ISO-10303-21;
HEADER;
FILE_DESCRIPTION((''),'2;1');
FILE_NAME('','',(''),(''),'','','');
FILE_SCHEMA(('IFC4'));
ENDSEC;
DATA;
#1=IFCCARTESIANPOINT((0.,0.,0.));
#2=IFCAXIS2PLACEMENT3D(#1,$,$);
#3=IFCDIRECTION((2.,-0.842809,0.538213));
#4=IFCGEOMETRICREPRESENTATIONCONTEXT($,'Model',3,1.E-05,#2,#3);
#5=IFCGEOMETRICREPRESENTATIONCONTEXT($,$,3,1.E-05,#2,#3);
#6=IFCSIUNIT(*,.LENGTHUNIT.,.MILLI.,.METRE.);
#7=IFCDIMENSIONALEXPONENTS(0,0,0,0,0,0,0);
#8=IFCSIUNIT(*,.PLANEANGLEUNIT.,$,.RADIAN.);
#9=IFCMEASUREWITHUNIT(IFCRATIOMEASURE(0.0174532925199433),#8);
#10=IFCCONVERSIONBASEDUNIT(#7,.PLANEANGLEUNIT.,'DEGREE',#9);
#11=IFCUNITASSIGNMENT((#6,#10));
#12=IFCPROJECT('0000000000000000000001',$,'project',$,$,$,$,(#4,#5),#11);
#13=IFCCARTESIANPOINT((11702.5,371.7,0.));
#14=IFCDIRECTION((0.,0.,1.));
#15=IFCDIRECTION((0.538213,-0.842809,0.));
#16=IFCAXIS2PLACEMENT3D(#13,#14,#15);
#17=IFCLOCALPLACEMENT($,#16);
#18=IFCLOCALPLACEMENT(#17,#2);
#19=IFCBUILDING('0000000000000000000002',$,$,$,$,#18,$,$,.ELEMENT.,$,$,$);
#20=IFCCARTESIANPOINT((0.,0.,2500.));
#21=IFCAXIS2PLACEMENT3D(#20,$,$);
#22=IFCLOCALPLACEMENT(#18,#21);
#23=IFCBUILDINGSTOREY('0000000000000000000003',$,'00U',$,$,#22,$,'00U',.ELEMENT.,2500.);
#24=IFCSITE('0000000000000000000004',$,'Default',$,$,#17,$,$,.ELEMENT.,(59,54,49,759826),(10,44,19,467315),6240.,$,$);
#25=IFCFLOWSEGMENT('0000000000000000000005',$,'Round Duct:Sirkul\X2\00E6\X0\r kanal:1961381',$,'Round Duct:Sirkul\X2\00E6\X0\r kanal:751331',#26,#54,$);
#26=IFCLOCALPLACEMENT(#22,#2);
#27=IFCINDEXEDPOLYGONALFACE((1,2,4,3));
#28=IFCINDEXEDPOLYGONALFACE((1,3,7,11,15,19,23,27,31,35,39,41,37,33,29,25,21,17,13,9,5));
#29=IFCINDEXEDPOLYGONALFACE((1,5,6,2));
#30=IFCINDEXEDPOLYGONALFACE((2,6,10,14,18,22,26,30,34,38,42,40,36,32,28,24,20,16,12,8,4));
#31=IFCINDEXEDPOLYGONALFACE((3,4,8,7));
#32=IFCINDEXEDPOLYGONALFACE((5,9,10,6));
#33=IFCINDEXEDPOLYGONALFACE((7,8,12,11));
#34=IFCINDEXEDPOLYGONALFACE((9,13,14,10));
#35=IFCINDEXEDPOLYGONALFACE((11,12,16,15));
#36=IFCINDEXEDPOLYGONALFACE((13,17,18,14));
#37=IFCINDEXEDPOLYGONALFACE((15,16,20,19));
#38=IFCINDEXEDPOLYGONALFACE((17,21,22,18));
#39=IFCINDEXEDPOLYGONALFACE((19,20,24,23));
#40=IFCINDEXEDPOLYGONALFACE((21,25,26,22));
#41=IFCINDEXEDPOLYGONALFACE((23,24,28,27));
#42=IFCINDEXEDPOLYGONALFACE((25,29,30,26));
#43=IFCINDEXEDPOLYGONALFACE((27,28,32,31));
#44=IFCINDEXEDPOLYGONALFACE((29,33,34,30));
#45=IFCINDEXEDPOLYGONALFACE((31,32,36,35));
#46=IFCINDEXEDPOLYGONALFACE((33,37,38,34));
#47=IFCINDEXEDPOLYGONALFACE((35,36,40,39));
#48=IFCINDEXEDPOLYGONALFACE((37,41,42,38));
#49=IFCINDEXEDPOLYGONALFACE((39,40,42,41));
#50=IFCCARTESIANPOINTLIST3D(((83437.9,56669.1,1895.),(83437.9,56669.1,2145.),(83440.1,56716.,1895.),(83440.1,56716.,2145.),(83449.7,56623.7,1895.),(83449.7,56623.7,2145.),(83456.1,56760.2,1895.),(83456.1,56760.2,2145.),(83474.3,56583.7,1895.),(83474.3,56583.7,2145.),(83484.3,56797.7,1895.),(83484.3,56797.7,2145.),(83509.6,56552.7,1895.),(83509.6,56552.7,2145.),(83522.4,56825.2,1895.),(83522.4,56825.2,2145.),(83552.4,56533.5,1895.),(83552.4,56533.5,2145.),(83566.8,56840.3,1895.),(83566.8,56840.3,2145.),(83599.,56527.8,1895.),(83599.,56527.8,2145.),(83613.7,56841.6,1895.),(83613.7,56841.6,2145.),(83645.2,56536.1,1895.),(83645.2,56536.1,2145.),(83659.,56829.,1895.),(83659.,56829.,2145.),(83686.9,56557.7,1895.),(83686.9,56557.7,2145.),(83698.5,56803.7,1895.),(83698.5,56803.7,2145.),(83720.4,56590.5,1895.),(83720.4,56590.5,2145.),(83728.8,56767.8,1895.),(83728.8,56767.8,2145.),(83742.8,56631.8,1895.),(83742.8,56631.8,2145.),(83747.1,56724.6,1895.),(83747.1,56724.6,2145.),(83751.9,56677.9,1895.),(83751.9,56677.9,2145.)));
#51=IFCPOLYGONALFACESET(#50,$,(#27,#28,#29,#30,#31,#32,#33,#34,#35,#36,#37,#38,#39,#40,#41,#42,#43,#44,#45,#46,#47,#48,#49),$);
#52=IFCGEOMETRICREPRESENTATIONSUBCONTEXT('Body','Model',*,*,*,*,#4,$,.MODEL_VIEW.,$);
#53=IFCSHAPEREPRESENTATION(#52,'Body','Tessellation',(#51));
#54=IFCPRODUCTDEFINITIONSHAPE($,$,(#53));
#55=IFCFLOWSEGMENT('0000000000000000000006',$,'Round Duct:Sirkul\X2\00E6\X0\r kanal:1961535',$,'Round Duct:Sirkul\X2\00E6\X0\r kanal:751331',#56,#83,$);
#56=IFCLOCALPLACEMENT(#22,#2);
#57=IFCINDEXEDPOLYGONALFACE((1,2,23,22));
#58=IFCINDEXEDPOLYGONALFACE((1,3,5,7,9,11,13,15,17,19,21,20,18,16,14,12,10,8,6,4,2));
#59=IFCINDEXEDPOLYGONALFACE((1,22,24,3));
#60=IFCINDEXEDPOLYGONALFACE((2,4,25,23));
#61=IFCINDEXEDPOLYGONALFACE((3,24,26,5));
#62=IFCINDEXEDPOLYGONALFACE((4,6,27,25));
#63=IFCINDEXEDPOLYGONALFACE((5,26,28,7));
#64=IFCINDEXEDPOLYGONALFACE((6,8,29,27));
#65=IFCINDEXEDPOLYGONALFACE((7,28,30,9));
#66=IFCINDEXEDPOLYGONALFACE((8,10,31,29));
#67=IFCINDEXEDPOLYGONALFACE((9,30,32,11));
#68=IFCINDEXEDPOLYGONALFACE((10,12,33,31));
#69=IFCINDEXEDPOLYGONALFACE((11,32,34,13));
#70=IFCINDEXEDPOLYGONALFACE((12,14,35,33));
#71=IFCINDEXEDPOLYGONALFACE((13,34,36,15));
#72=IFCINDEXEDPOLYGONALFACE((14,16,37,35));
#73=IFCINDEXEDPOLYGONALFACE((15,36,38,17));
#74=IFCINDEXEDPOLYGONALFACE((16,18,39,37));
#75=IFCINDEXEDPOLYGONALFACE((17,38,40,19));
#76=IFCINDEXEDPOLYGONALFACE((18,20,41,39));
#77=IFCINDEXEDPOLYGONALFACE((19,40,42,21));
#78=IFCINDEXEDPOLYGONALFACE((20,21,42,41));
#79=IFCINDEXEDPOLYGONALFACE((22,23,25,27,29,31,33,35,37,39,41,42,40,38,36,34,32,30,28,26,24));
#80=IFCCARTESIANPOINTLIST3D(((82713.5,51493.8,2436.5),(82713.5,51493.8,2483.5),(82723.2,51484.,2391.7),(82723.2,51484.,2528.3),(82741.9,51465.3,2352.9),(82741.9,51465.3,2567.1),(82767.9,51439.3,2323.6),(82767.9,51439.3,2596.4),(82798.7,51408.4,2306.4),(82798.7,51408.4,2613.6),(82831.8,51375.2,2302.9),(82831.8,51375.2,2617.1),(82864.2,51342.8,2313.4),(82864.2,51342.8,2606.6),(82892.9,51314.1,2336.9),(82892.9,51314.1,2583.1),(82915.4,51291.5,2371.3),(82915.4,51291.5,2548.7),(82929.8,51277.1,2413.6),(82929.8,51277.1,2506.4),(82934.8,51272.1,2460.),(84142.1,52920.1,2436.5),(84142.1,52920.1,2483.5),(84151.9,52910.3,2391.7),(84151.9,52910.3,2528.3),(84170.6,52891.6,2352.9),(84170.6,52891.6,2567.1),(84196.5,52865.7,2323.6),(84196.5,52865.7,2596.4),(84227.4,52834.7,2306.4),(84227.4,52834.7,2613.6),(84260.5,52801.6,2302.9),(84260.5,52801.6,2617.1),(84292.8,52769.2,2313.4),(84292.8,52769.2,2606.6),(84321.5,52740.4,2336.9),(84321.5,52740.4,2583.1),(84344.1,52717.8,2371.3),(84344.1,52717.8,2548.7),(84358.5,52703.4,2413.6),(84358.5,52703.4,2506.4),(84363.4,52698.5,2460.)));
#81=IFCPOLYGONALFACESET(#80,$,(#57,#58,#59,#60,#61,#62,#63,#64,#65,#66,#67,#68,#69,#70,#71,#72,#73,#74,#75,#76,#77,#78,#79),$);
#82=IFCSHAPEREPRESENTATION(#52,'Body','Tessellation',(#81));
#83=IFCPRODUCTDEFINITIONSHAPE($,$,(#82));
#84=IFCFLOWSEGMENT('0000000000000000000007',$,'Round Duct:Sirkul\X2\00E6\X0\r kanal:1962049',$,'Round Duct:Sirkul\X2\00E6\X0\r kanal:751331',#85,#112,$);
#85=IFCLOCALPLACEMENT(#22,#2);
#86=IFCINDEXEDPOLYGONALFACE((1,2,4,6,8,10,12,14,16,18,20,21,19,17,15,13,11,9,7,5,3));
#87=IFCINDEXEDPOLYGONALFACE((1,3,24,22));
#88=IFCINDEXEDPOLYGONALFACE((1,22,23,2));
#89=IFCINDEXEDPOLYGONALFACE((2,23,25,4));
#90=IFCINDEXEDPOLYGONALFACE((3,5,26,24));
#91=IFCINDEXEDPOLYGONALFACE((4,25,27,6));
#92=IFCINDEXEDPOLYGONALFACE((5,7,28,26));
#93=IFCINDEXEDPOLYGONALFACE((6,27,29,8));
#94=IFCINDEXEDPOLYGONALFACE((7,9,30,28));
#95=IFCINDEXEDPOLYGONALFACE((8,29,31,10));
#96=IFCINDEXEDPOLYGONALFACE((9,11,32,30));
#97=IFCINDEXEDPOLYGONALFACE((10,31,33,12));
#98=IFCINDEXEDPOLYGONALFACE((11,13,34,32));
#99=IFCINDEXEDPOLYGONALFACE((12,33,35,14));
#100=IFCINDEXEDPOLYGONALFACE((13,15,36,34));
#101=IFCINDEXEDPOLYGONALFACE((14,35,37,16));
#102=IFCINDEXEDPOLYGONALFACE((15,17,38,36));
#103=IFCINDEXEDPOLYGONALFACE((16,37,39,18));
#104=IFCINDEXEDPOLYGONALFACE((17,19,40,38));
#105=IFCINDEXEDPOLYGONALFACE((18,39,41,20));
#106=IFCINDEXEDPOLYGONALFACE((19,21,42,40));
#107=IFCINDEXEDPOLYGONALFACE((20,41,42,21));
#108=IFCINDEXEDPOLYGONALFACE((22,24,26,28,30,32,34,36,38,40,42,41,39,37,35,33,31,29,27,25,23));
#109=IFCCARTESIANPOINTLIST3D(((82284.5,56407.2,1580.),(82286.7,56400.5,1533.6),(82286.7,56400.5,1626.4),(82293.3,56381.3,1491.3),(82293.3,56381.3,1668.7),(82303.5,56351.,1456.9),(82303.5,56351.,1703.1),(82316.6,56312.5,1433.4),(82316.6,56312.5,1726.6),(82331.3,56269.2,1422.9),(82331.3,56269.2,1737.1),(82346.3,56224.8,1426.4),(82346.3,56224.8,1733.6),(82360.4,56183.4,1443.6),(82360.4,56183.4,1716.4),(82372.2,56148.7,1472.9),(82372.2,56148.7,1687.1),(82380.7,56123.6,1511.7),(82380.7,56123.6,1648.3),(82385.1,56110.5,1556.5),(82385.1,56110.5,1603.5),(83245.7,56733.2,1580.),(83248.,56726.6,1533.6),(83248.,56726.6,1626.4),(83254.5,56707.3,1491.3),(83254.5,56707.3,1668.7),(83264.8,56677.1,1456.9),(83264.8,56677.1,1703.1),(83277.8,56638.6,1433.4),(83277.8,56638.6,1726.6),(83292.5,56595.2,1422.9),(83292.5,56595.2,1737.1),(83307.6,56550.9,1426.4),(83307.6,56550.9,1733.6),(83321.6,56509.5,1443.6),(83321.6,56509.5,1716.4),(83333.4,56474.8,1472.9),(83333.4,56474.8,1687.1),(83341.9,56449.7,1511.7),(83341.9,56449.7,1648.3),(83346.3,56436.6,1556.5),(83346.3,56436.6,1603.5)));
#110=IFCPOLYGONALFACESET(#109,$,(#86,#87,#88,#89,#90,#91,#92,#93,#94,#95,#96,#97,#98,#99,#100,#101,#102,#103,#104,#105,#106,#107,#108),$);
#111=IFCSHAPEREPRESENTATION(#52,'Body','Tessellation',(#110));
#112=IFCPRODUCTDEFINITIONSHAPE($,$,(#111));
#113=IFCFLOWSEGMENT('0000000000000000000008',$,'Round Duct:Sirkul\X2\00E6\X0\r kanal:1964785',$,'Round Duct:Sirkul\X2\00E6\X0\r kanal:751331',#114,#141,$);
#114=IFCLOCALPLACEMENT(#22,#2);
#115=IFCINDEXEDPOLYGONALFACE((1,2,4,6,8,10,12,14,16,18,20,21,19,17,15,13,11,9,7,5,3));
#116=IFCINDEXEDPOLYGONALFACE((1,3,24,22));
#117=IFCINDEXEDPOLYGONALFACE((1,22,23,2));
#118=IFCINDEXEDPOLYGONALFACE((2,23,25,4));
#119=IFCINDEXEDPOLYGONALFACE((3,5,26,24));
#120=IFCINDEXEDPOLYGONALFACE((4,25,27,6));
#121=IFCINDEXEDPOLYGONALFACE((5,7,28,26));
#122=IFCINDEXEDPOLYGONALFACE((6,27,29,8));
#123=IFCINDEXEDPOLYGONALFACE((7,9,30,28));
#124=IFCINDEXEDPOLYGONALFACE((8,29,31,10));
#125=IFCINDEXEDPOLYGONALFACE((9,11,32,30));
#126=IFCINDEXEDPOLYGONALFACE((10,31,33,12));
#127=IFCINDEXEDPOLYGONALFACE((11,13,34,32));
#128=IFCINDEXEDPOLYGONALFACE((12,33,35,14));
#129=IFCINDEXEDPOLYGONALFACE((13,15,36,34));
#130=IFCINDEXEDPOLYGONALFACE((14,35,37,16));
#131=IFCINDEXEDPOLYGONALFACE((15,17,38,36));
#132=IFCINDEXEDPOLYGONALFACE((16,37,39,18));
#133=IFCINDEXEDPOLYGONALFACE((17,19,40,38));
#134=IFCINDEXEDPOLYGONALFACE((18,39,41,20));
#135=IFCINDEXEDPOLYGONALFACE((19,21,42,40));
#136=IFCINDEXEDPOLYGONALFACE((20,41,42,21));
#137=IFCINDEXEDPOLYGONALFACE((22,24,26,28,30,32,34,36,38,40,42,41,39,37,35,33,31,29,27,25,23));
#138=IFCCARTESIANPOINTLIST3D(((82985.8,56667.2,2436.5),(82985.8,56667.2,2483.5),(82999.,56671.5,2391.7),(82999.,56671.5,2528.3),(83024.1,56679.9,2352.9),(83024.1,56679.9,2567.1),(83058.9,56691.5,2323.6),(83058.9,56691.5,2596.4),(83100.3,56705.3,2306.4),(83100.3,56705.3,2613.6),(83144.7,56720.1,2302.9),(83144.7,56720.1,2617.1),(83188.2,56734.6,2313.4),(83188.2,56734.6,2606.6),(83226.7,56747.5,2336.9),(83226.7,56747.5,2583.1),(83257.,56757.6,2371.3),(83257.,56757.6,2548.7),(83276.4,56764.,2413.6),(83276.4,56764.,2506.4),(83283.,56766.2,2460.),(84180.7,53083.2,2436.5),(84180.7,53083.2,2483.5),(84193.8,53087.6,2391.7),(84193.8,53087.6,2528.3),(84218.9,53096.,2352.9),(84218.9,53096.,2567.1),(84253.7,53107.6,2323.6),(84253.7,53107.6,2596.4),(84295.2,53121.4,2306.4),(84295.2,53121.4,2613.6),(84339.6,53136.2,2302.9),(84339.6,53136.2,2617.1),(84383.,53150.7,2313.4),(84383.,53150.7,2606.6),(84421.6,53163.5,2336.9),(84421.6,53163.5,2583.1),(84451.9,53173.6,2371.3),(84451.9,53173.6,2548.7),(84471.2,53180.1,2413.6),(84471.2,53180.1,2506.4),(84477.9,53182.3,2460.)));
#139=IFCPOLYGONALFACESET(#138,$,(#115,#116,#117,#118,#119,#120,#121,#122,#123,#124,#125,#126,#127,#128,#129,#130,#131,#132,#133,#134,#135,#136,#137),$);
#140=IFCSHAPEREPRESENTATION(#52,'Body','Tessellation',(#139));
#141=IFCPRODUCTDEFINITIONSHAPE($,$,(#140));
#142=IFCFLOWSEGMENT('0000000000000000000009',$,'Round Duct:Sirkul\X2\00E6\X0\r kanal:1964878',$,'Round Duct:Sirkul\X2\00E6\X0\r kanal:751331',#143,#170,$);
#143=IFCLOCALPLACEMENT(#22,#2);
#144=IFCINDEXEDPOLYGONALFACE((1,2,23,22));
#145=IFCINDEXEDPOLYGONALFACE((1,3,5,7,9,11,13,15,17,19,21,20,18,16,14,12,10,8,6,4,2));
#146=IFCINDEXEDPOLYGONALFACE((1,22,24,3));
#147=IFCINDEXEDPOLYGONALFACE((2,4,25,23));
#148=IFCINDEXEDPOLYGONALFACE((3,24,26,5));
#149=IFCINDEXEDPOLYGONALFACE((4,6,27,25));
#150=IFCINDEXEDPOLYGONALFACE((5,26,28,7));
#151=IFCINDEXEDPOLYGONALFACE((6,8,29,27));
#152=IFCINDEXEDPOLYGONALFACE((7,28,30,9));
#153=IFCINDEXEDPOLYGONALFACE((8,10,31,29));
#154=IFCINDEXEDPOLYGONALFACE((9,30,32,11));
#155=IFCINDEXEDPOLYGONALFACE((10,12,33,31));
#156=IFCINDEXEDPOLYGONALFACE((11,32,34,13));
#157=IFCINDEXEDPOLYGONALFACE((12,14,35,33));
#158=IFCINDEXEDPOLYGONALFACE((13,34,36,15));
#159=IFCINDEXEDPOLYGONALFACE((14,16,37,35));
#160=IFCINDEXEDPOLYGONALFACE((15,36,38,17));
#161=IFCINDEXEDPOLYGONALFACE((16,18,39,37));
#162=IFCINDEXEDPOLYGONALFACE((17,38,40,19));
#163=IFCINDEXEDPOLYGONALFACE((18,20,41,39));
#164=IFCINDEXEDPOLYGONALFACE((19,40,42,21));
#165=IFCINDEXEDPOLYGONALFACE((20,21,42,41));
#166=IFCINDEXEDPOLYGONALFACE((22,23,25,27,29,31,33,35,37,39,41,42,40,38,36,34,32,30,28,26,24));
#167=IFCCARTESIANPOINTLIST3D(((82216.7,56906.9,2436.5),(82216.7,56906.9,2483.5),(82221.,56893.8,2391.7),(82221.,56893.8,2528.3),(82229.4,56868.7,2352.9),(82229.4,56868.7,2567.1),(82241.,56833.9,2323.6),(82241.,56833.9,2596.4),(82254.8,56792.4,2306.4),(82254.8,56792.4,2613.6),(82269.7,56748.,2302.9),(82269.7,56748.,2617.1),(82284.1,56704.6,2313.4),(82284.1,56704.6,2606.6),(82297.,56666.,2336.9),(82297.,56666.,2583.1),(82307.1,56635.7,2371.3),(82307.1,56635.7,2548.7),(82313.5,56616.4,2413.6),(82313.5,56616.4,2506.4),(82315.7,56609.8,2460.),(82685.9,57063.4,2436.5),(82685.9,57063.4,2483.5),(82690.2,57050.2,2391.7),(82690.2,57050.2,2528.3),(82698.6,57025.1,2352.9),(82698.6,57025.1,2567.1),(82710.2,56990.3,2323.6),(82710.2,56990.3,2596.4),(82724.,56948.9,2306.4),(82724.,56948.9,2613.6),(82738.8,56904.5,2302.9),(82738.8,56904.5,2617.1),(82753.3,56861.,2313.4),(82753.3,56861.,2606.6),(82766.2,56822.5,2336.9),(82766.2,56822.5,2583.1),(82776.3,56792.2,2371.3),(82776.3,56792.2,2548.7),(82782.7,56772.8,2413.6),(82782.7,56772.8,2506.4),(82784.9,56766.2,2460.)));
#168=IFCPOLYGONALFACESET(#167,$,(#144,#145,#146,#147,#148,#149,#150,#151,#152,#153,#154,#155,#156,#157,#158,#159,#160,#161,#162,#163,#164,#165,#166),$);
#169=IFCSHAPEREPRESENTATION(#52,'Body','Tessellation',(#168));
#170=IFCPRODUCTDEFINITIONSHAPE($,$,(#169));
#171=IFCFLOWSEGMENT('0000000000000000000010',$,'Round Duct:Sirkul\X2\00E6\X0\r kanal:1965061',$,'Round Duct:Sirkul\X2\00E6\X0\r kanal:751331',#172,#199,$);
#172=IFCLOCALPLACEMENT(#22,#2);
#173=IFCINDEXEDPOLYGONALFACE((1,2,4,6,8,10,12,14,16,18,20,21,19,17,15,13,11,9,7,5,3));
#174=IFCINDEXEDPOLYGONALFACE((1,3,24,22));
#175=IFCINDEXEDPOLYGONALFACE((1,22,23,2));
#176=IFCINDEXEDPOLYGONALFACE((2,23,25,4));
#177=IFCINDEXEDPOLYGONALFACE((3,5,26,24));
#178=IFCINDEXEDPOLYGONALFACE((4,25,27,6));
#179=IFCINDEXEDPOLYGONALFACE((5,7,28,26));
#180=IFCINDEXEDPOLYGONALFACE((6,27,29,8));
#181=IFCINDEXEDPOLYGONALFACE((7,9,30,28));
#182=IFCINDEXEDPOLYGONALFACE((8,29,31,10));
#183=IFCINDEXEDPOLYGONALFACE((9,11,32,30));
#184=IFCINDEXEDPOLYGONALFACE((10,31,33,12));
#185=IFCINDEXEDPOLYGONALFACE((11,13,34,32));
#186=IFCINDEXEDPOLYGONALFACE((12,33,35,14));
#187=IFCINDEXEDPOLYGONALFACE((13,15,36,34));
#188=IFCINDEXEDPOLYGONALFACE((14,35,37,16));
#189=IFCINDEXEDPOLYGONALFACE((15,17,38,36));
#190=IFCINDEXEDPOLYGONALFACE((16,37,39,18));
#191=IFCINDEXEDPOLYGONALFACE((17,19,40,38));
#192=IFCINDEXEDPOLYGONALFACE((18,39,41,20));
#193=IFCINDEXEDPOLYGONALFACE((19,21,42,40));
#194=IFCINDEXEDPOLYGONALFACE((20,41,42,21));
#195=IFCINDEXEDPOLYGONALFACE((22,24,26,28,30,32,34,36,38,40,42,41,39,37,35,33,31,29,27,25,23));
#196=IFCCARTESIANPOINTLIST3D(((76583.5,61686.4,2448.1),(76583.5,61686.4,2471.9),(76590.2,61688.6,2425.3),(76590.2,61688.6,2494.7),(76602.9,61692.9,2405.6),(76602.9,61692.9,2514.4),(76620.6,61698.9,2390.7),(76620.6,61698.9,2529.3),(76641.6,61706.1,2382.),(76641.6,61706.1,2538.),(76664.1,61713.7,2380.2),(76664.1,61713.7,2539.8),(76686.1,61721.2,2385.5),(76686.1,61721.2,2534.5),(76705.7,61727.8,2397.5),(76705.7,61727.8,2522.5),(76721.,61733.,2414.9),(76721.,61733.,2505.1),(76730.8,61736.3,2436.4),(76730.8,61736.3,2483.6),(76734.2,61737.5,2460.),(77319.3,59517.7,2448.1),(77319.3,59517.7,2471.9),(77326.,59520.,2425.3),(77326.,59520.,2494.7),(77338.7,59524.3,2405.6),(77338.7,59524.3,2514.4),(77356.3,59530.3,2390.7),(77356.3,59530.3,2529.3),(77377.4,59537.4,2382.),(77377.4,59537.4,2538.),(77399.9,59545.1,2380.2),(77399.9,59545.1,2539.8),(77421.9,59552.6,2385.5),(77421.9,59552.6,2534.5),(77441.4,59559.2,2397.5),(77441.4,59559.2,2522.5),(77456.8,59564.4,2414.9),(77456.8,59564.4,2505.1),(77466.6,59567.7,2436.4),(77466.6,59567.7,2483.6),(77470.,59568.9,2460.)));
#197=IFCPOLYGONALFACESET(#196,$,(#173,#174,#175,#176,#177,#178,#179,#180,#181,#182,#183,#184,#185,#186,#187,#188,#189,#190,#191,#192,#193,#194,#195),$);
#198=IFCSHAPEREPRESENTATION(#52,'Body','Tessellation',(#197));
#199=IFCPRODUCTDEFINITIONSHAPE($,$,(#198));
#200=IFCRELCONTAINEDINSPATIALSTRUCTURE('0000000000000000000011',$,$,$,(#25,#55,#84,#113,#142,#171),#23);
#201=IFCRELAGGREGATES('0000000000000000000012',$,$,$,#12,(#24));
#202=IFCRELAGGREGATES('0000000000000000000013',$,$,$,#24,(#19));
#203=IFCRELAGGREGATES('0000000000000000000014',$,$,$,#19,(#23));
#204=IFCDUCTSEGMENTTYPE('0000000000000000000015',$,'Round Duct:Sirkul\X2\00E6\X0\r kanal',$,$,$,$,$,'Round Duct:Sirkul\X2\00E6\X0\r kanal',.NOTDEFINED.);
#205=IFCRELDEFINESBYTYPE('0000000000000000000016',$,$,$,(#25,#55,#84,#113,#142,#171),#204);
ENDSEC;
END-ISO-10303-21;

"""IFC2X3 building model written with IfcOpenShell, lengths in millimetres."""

from ifc_helpers import new_model, entity, si_unit, converted_unit, direction, frame, frame_2d, origin, origin_2d_with_axis, place, context, subcontext, project, spatial, circle, extrude, type_object, element, save


model = new_model("IFC2X3")

# Units and contexts
model_context = context("Model", 3, precision=1e-05, world=origin(), true_north=direction((2.0, -0.842809, 0.538213)))
context_of_model = context(None, 3, precision=1e-05, world=origin(), true_north=direction((2.0, -0.842809, 0.538213)))
body_context = subcontext(model_context, "Body", "Model", "MODEL_VIEW")
ifc_project = project(units=[si_unit("LENGTHUNIT", "METRE", prefix="MILLI"), converted_unit("PLANEANGLEUNIT", "DEGREE", entity("IfcRatioMeasure", 0.0174532925199433), si_unit("PLANEANGLEUNIT", "RADIAN"), dimensions=[0, 0, 0, 0, 0, 0, 0])], contexts=[model_context, context_of_model])

# Site, building, storey
site_placement = place(None, frame((11702.5, 371.7, 0.0), z_axis=(0.0, 0.0, 1.0), x_axis=(0.538213, -0.842809, 0.0)))
site = spatial("IfcSite", under=ifc_project, at=site_placement, Name="Default", CompositionType="ELEMENT", RefLatitude=(59, 54, 49, 759826), RefLongitude=(10, 44, 19, 467315), RefElevation=6240.0)
building_placement = place(site_placement, origin())
building = spatial("IfcBuilding", under=site, at=building_placement, CompositionType="ELEMENT")
storey_placement = place(building_placement, frame((0.0, 0.0, 2500.0)))
storey = spatial("IfcBuildingStorey", under=building, at=storey_placement, Name="00U", LongName="00U", CompositionType="ELEMENT", Elevation=2500.0)

# Flow segments
duct_segment_type_1 = type_object("IfcDuctSegmentType", Name="Round Duct:Sirkulær kanal", ElementType="Round Duct:Sirkulær kanal", PredefinedType="NOTDEFINED")
flow_segment_1_placement = place(storey_placement, origin())
element("IfcFlowSegment", 1, at=flow_segment_1_placement, inside=storey, type_object=duct_segment_type_1, Name="Round Duct:Sirkulær kanal:1961381", ObjectType="Round Duct:Sirkulær kanal:751331", context=body_context, shape_type="SweptSolid", body=[
    extrude(circle(Radius=157.5, at=origin_2d_with_axis()), frame((83594.6, 56685.3, 1895.0), z_axis=(0.0, 0.0, 1.0), x_axis=(0.321246, -0.946996, 0.0)), (0.0, 0.0, 1.0), 250.0),
])
flow_segment_2_placement = place(storey_placement, origin())
element("IfcFlowSegment", 2, at=flow_segment_2_placement, inside=storey, type_object=duct_segment_type_1, Name="Round Duct:Sirkulær kanal:1961535", ObjectType="Round Duct:Sirkulær kanal:751331", context=body_context, shape_type="SweptSolid", body=[
    extrude(circle(Radius=157.5, at=origin_2d_with_axis()), frame((82823.5, 51383.6, 2460.0), z_axis=(0.707677, 0.706536, 0.0), x_axis=(0.706536, -0.707677, 0.0)), (0.0, 0.0, 1.0), 2018.8),
])
flow_segment_3_placement = place(storey_placement, origin())
element("IfcFlowSegment", 3, at=flow_segment_3_placement, inside=storey, type_object=duct_segment_type_1, Name="Round Duct:Sirkulær kanal:1962049", ObjectType="Round Duct:Sirkulær kanal:751331", context=body_context, shape_type="SweptSolid", body=[
    extrude(circle(Radius=157.5, at=frame_2d((0.0, 0.0), x_axis=(1.0, 0.0))), frame((82335.1, 56258.0, 1580.0), z_axis=(0.946996, 0.321246, 0.0), x_axis=(-0.321246, 0.946996, 0.0)), (0.0, 0.0, 1.0), 1015.0),
])
flow_segment_4_placement = place(storey_placement, origin())
element("IfcFlowSegment", 4, at=flow_segment_4_placement, inside=storey, type_object=duct_segment_type_1, Name="Round Duct:Sirkulær kanal:1964785", ObjectType="Round Duct:Sirkulær kanal:751331", context=body_context, shape_type="SweptSolid", body=[
    extrude(circle(Radius=157.5, at=origin_2d_with_axis()), frame((84328.4, 53132.5, 2460.0), z_axis=(-0.316277, 0.948667, 0.0), x_axis=(0.948667, 0.316277, 0.0)), (0.0, 0.0, 1.0), 3777.9),
])
flow_segment_5_placement = place(storey_placement, origin())
element("IfcFlowSegment", 5, at=flow_segment_5_placement, inside=storey, type_object=duct_segment_type_1, Name="Round Duct:Sirkulær kanal:1964878", ObjectType="Round Duct:Sirkulær kanal:751331", context=body_context, shape_type="SweptSolid", body=[
    extrude(circle(Radius=157.5, at=origin_2d_with_axis()), frame((82265.9, 56759.2, 2460.0), z_axis=(0.948667, 0.316277, 0.0), x_axis=(0.316277, -0.948667, 0.0)), (0.0, 0.0, 1.0), 494.6),
])
flow_segment_6_placement = place(storey_placement, origin())
element("IfcFlowSegment", 6, at=flow_segment_6_placement, inside=storey, type_object=duct_segment_type_1, Name="Round Duct:Sirkulær kanal:1965061", ObjectType="Round Duct:Sirkulær kanal:751331", context=body_context, shape_type="SweptSolid", body=[
    extrude(circle(Radius=80.0, at=frame_2d((0.0, 0.0), x_axis=(1.0, 0.0))), frame((76658.4, 61711.8, 2460.0), z_axis=(0.321291, -0.94698, 0.0), x_axis=(0.94698, 0.321291, 0.0)), (0.0, 0.0, 1.0), 2290.0),
])

save(model, "model.ifc")
